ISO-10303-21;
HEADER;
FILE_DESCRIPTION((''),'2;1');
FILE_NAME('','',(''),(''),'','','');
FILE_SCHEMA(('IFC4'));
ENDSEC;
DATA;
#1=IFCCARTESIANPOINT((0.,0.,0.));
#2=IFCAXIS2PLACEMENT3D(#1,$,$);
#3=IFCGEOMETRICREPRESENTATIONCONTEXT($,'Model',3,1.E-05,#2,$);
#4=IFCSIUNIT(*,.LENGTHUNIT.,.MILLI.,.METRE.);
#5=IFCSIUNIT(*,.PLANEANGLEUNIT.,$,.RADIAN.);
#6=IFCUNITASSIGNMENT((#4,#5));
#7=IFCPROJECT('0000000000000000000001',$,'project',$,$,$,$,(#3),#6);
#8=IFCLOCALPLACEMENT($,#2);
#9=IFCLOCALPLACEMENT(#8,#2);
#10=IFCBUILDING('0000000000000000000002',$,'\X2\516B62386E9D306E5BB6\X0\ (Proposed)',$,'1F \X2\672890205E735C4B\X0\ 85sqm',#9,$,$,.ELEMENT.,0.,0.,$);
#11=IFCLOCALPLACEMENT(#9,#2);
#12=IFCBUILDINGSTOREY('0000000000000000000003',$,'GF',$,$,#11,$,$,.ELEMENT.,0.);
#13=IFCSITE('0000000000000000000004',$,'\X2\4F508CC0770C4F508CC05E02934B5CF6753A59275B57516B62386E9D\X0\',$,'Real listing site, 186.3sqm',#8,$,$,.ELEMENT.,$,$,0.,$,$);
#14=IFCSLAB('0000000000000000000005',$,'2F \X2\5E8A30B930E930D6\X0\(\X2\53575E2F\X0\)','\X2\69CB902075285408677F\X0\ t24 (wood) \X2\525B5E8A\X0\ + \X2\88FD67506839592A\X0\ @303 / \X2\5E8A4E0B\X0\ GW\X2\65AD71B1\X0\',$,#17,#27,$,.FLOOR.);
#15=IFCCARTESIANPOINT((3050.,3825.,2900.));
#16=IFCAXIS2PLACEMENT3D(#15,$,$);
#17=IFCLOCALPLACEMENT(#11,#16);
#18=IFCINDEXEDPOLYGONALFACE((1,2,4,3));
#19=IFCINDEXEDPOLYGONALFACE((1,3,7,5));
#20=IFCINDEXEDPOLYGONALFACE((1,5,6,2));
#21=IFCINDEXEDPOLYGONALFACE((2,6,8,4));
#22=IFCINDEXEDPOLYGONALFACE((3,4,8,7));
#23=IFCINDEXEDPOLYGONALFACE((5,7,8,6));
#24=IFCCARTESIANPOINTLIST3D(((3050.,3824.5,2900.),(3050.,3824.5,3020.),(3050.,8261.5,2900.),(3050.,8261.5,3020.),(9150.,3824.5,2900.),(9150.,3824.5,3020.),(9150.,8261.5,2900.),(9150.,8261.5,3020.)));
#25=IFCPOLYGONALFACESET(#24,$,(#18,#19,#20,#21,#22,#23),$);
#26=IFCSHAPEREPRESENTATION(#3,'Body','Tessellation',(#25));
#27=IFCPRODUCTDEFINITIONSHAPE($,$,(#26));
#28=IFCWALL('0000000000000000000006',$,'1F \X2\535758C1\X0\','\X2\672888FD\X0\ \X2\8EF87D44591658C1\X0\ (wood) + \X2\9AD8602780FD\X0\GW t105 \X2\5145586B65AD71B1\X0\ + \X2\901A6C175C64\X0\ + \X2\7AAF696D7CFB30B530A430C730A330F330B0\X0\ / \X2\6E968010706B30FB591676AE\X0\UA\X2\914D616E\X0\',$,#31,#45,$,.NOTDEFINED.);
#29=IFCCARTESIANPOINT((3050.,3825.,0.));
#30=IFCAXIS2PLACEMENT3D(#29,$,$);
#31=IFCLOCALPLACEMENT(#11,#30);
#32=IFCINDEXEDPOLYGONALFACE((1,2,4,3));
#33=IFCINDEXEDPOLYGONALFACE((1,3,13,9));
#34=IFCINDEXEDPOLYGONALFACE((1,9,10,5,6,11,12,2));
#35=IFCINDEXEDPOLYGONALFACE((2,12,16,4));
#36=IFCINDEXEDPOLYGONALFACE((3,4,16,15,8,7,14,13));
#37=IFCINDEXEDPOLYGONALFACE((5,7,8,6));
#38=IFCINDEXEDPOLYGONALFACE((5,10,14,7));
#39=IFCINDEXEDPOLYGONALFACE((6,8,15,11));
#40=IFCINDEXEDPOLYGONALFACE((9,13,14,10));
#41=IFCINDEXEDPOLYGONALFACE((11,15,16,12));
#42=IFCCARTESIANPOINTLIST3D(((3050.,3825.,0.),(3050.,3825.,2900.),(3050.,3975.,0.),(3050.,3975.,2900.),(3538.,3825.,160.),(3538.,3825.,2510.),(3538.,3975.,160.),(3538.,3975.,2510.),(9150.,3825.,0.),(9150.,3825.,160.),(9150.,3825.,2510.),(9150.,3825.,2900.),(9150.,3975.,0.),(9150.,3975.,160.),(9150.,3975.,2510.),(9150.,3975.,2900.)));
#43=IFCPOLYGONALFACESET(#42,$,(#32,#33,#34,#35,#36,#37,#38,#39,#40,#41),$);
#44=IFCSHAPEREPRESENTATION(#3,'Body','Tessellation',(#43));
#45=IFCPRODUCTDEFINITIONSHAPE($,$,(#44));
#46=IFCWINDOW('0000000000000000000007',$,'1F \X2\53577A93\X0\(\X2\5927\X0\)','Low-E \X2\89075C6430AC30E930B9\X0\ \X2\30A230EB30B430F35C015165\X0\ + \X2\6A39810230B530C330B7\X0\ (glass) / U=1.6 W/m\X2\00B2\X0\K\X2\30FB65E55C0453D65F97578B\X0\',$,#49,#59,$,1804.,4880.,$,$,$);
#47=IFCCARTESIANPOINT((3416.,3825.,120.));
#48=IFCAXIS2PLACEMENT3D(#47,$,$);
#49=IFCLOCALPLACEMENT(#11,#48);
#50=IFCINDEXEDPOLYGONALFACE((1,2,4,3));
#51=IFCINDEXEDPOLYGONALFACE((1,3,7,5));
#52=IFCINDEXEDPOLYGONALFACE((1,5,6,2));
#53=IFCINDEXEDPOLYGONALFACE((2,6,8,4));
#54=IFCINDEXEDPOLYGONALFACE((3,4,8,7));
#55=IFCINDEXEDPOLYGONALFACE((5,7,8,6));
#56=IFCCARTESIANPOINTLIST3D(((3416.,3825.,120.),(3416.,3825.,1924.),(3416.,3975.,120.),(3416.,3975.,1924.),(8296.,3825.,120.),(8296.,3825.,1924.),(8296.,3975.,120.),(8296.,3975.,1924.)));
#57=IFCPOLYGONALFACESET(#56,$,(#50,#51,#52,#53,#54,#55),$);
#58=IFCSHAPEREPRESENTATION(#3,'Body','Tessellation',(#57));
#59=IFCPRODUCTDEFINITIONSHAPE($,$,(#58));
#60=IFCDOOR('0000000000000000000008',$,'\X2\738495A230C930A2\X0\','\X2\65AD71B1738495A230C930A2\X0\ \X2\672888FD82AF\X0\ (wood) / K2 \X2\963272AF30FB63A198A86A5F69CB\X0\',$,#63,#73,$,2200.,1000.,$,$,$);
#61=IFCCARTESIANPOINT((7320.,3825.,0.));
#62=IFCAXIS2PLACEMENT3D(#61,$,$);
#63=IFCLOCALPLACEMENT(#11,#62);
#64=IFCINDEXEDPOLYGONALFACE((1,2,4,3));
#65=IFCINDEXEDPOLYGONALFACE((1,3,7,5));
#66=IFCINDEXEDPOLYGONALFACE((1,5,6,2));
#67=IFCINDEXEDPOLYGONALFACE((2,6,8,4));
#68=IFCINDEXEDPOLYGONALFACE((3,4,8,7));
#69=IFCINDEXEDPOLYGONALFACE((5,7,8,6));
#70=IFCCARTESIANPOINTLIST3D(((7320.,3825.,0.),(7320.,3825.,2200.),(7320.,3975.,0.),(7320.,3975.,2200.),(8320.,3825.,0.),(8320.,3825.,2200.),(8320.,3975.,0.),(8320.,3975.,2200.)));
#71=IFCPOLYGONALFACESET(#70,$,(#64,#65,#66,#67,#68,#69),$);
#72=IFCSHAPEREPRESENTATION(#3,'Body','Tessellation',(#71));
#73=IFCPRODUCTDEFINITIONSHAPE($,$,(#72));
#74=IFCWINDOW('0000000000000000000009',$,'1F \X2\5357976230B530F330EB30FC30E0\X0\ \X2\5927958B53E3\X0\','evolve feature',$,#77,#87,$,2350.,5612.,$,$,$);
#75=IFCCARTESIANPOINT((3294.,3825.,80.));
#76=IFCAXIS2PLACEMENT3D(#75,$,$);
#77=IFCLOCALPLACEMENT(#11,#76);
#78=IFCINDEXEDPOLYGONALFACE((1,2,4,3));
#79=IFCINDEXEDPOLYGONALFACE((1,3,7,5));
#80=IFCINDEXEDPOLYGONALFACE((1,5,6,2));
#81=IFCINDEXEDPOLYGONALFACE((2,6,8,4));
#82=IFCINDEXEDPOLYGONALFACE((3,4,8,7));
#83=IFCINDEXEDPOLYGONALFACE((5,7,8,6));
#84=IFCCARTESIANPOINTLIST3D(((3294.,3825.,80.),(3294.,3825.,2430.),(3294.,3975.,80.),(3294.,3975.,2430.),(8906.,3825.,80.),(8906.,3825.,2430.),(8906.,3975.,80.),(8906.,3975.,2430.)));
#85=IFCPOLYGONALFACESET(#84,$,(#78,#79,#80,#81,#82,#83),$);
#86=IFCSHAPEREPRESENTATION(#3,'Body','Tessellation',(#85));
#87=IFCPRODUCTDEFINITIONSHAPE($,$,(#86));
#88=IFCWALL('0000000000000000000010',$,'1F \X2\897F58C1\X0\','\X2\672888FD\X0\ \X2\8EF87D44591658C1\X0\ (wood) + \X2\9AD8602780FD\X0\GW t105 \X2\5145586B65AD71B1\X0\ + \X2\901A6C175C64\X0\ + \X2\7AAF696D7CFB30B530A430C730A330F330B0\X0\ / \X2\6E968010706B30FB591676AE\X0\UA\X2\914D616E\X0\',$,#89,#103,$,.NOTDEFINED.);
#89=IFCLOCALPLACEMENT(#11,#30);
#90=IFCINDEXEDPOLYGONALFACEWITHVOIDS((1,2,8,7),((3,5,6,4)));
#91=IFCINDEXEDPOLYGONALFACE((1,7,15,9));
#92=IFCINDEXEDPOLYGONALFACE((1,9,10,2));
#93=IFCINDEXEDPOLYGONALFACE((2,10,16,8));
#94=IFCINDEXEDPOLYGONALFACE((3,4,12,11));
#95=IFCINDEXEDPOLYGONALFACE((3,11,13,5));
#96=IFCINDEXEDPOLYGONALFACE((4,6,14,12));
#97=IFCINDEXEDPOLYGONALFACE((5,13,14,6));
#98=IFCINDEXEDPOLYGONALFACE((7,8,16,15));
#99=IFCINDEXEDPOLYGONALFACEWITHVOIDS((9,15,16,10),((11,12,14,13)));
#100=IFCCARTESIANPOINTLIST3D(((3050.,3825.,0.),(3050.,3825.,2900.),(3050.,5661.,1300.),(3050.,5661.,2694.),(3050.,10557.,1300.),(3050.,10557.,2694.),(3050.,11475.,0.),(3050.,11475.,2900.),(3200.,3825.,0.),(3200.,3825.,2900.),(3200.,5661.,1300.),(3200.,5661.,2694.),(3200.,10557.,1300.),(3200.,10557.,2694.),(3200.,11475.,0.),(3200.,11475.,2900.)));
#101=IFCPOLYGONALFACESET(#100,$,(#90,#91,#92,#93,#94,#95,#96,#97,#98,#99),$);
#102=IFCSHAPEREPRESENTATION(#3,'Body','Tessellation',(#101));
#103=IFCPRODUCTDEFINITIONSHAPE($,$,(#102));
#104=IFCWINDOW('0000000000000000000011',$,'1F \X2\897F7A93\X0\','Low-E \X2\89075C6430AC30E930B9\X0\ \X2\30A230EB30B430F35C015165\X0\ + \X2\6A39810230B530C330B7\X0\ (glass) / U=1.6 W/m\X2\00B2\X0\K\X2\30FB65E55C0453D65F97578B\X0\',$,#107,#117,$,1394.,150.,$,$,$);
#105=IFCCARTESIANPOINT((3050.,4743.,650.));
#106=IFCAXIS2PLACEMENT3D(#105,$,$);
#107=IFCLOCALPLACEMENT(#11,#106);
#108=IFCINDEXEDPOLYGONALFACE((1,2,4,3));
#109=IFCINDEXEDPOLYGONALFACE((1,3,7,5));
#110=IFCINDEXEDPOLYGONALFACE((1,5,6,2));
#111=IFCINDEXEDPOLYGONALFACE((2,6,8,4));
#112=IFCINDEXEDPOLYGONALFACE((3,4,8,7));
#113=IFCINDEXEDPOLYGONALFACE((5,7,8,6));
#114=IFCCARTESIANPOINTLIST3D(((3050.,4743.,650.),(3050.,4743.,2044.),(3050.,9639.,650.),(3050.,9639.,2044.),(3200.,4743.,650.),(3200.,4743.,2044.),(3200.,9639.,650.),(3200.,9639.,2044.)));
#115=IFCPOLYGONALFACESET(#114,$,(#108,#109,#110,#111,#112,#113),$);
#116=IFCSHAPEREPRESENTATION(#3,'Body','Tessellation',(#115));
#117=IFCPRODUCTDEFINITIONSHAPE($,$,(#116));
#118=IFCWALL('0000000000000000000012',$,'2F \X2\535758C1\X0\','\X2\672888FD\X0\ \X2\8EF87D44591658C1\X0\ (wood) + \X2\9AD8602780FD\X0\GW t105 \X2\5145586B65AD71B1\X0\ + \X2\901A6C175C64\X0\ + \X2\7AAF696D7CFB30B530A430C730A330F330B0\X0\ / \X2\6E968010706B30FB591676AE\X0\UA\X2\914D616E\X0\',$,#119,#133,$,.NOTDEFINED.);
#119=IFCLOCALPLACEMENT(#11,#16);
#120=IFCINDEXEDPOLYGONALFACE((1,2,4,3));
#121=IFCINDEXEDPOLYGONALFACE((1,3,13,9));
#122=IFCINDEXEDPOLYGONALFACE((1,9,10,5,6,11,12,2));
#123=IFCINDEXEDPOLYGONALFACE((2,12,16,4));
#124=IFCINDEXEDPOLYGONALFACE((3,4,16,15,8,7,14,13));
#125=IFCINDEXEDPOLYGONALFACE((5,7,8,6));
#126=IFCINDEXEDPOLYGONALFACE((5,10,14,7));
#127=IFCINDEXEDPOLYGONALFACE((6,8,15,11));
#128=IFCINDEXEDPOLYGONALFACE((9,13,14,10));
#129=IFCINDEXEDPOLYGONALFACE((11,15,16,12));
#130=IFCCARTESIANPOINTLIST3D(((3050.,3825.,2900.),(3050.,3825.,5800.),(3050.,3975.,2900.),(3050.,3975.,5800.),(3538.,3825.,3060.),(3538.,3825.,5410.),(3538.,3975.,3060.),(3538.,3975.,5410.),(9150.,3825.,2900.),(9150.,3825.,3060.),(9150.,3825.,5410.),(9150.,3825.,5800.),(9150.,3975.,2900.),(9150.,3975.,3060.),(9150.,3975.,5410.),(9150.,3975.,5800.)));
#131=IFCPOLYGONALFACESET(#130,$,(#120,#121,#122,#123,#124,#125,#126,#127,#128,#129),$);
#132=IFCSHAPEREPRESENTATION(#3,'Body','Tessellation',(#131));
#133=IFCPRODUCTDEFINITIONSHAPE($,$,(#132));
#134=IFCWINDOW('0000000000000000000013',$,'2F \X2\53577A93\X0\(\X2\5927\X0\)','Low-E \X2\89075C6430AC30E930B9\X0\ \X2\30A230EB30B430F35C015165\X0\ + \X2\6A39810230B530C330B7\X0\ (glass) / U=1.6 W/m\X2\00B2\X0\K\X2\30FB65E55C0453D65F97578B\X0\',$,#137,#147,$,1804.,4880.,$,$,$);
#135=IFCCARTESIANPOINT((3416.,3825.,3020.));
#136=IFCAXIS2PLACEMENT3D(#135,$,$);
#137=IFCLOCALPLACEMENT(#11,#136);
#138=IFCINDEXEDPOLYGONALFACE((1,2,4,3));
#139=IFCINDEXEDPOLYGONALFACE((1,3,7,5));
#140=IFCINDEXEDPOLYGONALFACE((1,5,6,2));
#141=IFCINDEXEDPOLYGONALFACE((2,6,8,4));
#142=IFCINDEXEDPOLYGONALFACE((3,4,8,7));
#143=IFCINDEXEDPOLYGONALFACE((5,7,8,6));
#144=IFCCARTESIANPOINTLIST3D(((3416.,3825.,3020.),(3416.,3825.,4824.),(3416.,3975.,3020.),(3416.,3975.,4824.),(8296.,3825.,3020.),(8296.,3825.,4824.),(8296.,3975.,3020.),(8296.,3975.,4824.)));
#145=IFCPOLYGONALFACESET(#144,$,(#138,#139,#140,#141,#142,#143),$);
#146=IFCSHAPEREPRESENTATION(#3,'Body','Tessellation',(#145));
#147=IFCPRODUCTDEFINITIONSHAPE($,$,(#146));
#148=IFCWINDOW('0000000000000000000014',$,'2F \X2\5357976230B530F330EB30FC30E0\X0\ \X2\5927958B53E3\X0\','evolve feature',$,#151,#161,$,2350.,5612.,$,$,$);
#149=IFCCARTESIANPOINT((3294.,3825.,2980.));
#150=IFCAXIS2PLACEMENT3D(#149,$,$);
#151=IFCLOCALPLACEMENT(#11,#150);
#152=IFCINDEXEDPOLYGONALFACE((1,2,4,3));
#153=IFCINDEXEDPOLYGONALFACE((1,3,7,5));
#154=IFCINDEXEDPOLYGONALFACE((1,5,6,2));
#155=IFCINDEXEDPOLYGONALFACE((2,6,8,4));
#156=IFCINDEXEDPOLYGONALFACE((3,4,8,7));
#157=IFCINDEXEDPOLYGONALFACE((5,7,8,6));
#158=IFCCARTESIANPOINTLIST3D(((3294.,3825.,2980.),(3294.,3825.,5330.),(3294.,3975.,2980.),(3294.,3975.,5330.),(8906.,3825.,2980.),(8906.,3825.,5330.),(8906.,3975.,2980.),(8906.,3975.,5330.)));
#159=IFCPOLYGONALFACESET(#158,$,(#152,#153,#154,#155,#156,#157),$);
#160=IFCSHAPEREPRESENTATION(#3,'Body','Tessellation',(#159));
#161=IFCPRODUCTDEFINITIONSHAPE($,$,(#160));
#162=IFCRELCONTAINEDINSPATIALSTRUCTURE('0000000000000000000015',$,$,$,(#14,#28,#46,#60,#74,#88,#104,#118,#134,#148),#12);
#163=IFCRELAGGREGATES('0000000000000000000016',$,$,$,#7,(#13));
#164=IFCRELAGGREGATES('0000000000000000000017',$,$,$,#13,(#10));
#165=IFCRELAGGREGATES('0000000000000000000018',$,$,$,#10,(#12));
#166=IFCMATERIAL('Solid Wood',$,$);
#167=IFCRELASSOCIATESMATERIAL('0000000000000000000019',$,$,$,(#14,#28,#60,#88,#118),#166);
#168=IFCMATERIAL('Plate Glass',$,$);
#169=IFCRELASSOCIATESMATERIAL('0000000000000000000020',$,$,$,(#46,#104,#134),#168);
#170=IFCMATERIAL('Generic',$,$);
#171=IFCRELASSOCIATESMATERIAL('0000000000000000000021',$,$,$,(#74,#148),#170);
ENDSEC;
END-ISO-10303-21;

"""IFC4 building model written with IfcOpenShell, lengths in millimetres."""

from ifc_helpers import new_model, si_unit, frame, frame_2d, origin, place, context, project, spatial, rectangle, extrude, material, element, fill, save


model = new_model("IFC4")

# Units and contexts
model_context = context("Model", 3, precision=1e-05, world=origin())
ifc_project = project(units=[si_unit("LENGTHUNIT", "METRE", prefix="MILLI"), si_unit("PLANEANGLEUNIT", "RADIAN")], contexts=[model_context])

# Site, building, storey
site_placement = place(None, origin())
site = spatial("IfcSite", under=ifc_project, at=site_placement, Name="佐賀県佐賀市鍋島町大字八戸溝", ObjectType="Real listing site, 186.3sqm", CompositionType="ELEMENT", RefElevation=0.0)
building_placement = place(site_placement, origin())
building = spatial("IfcBuilding", under=site, at=building_placement, Name="八戸溝の家 (Proposed)", ObjectType="1F 木造平屋 85sqm", CompositionType="ELEMENT", ElevationOfRefHeight=0.0, ElevationOfTerrain=0.0)
storey_placement = place(building_placement, origin())
storey = spatial("IfcBuildingStorey", under=building, at=storey_placement, Name="GF", CompositionType="ELEMENT", Elevation=0.0)

# Slab
ifc_material_1 = material(Name="Solid Wood")
slab_1_placement = place(storey_placement, frame((3050.0, 3825.0, 2900.0)))
element("IfcSlab", 1, at=slab_1_placement, inside=storey, material=ifc_material_1, Name="2F 床スラブ(南帯)", Description="構造用合板 t24 (wood) 剛床 + 製材根太 @303 / 床下 GW断熱", PredefinedType="FLOOR", context=model_context, shape_type="SweptSolid", body=[
    extrude(rectangle(XDim=6100.0, YDim=4437.0, at=frame_2d((3050.0, 2218.0))), frame((3050.0, 3825.0, 2900.0)), (0.0, 0.0, 1.0), 120.0),
])
ifc_material_2 = material(Name="Generic")

# Wall, openings, windows, door
wall_1_placement = place(storey_placement, frame((3050.0, 3825.0, 0.0)))
wall_1 = element("IfcWall", 2, at=wall_1_placement, inside=storey, material=ifc_material_1, Name="1F 南壁", Description="木製 軸組外壁 (wood) + 高性能GW t105 充填断熱 + 通気層 + 窯業系サイディング / 準耐火・外皮UA配慮", PredefinedType="NOTDEFINED", context=model_context, shape_type="SweptSolid", body=[
    extrude(rectangle(XDim=6100.0, YDim=150.0, at=frame_2d((3050.0, 75.0))), frame((3050.0, 3825.0, 0.0)), (0.0, 0.0, 1.0), 2900.0),
])
opening_1_placement = place(storey_placement, frame((3416.0, 3825.0, 120.0)))
opening_1 = element("IfcOpeningElement", 3, at=opening_1_placement, cuts=wall_1, PredefinedType="NOTDEFINED", context=model_context, shape_type="SweptSolid", body=[
    extrude(rectangle(XDim=4880.0, YDim=150.0, at=frame_2d((2440.0, 75.0))), frame((3416.0, 3825.0, 120.0)), (0.0, 0.0, 1.0), 1804.0),
])
opening_2_placement = place(storey_placement, frame((7320.0, 3825.0, 0.0)))
opening_2 = element("IfcOpeningElement", 4, at=opening_2_placement, cuts=wall_1, PredefinedType="NOTDEFINED", context=model_context, shape_type="SweptSolid", body=[
    extrude(rectangle(XDim=1000.0, YDim=150.0, at=frame_2d((500.0, 75.0))), frame((7320.0, 3825.0, 0.0)), (0.0, 0.0, 1.0), 2200.0),
])
opening_3_placement = place(storey_placement, frame((3294.0, 3825.0, 80.0)))
opening_3 = element("IfcOpeningElement", 5, at=opening_3_placement, cuts=wall_1, PredefinedType="NOTDEFINED", context=model_context, shape_type="SweptSolid", body=[
    extrude(rectangle(XDim=5612.0, YDim=150.0, at=frame_2d((2806.0, 75.0))), frame((3294.0, 3825.0, 80.0)), (0.0, 0.0, 1.0), 2350.0),
])
ifc_material_3 = material(Name="Plate Glass")
window_1_placement = place(storey_placement, frame((3416.0, 3825.0, 120.0)))
window_1 = element("IfcWindow", 6, at=window_1_placement, inside=storey, material=ifc_material_3, Name="1F 南窓(大)", Description="Low-E 複層ガラス アルゴン封入 + 樹脂サッシ (glass) / U=1.6 W/m²K・日射取得型", OverallHeight=1804.0, OverallWidth=4880.0, context=model_context, shape_type="SweptSolid", body=[
    extrude(rectangle(XDim=4880.0, YDim=150.0, at=frame_2d((2440.0, 75.0))), frame((3416.0, 3825.0, 120.0)), (0.0, 0.0, 1.0), 1804.0),
])
fill(opening_1, window_1)
door_placement = place(storey_placement, frame((7320.0, 3825.0, 0.0)))
door = element("IfcDoor", 7, at=door_placement, inside=storey, material=ifc_material_1, Name="玄関ドア", Description="断熱玄関ドア 木製芯 (wood) / K2 防犯・採風機構", OverallHeight=2200.0, OverallWidth=1000.0, context=model_context, shape_type="SweptSolid", body=[
    extrude(rectangle(XDim=1000.0, YDim=150.0, at=frame_2d((500.0, 75.0))), frame((7320.0, 3825.0, 0.0)), (0.0, 0.0, 1.0), 2200.0),
])
fill(opening_2, door)
window_2_placement = place(storey_placement, frame((3294.0, 3825.0, 80.0)))
window_2 = element("IfcWindow", 8, at=window_2_placement, inside=storey, material=ifc_material_2, Name="1F 南面サンルーム 大開口", Description="evolve feature", OverallHeight=2350.0, OverallWidth=5612.0, context=model_context, shape_type="SweptSolid", body=[
    extrude(rectangle(XDim=5612.0, YDim=150.0, at=frame_2d((2806.0, 75.0))), frame((3294.0, 3825.0, 80.0)), (0.0, 0.0, 1.0), 2350.0),
])
fill(opening_3, window_2)

# Wall, opening, window
wall_2_placement = place(storey_placement, frame((3050.0, 3825.0, 0.0)))
wall_2 = element("IfcWall", 9, at=wall_2_placement, inside=storey, material=ifc_material_1, Name="1F 西壁", Description="木製 軸組外壁 (wood) + 高性能GW t105 充填断熱 + 通気層 + 窯業系サイディング / 準耐火・外皮UA配慮", PredefinedType="NOTDEFINED", context=model_context, shape_type="SweptSolid", body=[
    extrude(rectangle(XDim=150.0, YDim=7650.0, at=frame_2d((75.0, 3825.0))), frame((3050.0, 3825.0, 0.0)), (0.0, 0.0, 1.0), 2900.0),
])
opening_4_placement = place(storey_placement, frame((3050.0, 4743.0, 650.0)))
opening_4 = element("IfcOpeningElement", 10, at=opening_4_placement, cuts=wall_2, PredefinedType="NOTDEFINED", context=model_context, shape_type="SweptSolid", body=[
    extrude(rectangle(XDim=150.0, YDim=4896.0, at=frame_2d((75.0, 2448.0))), frame((3050.0, 4743.0, 650.0)), (0.0, 0.0, 1.0), 1394.0),
])
window_3_placement = place(storey_placement, frame((3050.0, 4743.0, 650.0)))
window_3 = element("IfcWindow", 11, at=window_3_placement, inside=storey, material=ifc_material_3, Name="1F 西窓", Description="Low-E 複層ガラス アルゴン封入 + 樹脂サッシ (glass) / U=1.6 W/m²K・日射取得型", OverallHeight=1394.0, OverallWidth=150.0, context=model_context, shape_type="SweptSolid", body=[
    extrude(rectangle(XDim=150.0, YDim=4896.0, at=frame_2d((75.0, 2448.0))), frame((3050.0, 4743.0, 650.0)), (0.0, 0.0, 1.0), 1394.0),
])
fill(opening_4, window_3)

# Wall, openings, windows
wall_3_placement = place(storey_placement, frame((3050.0, 3825.0, 2900.0)))
wall_3 = element("IfcWall", 12, at=wall_3_placement, inside=storey, material=ifc_material_1, Name="2F 南壁", Description="木製 軸組外壁 (wood) + 高性能GW t105 充填断熱 + 通気層 + 窯業系サイディング / 準耐火・外皮UA配慮", PredefinedType="NOTDEFINED", context=model_context, shape_type="SweptSolid", body=[
    extrude(rectangle(XDim=6100.0, YDim=150.0, at=frame_2d((3050.0, 75.0))), frame((3050.0, 3825.0, 2900.0)), (0.0, 0.0, 1.0), 2900.0),
])
opening_5_placement = place(storey_placement, frame((3416.0, 3825.0, 3020.0)))
opening_5 = element("IfcOpeningElement", 13, at=opening_5_placement, cuts=wall_3, PredefinedType="NOTDEFINED", context=model_context, shape_type="SweptSolid", body=[
    extrude(rectangle(XDim=4880.0, YDim=150.0, at=frame_2d((2440.0, 75.0))), frame((3416.0, 3825.0, 3020.0)), (0.0, 0.0, 1.0), 1804.0),
])
opening_6_placement = place(storey_placement, frame((3294.0, 3825.0, 2980.0)))
opening_6 = element("IfcOpeningElement", 14, at=opening_6_placement, cuts=wall_3, PredefinedType="NOTDEFINED", context=model_context, shape_type="SweptSolid", body=[
    extrude(rectangle(XDim=5612.0, YDim=150.0, at=frame_2d((2806.0, 75.0))), frame((3294.0, 3825.0, 2980.0)), (0.0, 0.0, 1.0), 2350.0),
])
window_4_placement = place(storey_placement, frame((3416.0, 3825.0, 3020.0)))
window_4 = element("IfcWindow", 15, at=window_4_placement, inside=storey, material=ifc_material_3, Name="2F 南窓(大)", Description="Low-E 複層ガラス アルゴン封入 + 樹脂サッシ (glass) / U=1.6 W/m²K・日射取得型", OverallHeight=1804.0, OverallWidth=4880.0, context=model_context, shape_type="SweptSolid", body=[
    extrude(rectangle(XDim=4880.0, YDim=150.0, at=frame_2d((2440.0, 75.0))), frame((3416.0, 3825.0, 3020.0)), (0.0, 0.0, 1.0), 1804.0),
])
fill(opening_5, window_4)
window_5_placement = place(storey_placement, frame((3294.0, 3825.0, 2980.0)))
window_5 = element("IfcWindow", 16, at=window_5_placement, inside=storey, material=ifc_material_2, Name="2F 南面サンルーム 大開口", Description="evolve feature", OverallHeight=2350.0, OverallWidth=5612.0, context=model_context, shape_type="SweptSolid", body=[
    extrude(rectangle(XDim=5612.0, YDim=150.0, at=frame_2d((2806.0, 75.0))), frame((3294.0, 3825.0, 2980.0)), (0.0, 0.0, 1.0), 2350.0),
])
fill(opening_6, window_5)

save(model, "model.ifc")
